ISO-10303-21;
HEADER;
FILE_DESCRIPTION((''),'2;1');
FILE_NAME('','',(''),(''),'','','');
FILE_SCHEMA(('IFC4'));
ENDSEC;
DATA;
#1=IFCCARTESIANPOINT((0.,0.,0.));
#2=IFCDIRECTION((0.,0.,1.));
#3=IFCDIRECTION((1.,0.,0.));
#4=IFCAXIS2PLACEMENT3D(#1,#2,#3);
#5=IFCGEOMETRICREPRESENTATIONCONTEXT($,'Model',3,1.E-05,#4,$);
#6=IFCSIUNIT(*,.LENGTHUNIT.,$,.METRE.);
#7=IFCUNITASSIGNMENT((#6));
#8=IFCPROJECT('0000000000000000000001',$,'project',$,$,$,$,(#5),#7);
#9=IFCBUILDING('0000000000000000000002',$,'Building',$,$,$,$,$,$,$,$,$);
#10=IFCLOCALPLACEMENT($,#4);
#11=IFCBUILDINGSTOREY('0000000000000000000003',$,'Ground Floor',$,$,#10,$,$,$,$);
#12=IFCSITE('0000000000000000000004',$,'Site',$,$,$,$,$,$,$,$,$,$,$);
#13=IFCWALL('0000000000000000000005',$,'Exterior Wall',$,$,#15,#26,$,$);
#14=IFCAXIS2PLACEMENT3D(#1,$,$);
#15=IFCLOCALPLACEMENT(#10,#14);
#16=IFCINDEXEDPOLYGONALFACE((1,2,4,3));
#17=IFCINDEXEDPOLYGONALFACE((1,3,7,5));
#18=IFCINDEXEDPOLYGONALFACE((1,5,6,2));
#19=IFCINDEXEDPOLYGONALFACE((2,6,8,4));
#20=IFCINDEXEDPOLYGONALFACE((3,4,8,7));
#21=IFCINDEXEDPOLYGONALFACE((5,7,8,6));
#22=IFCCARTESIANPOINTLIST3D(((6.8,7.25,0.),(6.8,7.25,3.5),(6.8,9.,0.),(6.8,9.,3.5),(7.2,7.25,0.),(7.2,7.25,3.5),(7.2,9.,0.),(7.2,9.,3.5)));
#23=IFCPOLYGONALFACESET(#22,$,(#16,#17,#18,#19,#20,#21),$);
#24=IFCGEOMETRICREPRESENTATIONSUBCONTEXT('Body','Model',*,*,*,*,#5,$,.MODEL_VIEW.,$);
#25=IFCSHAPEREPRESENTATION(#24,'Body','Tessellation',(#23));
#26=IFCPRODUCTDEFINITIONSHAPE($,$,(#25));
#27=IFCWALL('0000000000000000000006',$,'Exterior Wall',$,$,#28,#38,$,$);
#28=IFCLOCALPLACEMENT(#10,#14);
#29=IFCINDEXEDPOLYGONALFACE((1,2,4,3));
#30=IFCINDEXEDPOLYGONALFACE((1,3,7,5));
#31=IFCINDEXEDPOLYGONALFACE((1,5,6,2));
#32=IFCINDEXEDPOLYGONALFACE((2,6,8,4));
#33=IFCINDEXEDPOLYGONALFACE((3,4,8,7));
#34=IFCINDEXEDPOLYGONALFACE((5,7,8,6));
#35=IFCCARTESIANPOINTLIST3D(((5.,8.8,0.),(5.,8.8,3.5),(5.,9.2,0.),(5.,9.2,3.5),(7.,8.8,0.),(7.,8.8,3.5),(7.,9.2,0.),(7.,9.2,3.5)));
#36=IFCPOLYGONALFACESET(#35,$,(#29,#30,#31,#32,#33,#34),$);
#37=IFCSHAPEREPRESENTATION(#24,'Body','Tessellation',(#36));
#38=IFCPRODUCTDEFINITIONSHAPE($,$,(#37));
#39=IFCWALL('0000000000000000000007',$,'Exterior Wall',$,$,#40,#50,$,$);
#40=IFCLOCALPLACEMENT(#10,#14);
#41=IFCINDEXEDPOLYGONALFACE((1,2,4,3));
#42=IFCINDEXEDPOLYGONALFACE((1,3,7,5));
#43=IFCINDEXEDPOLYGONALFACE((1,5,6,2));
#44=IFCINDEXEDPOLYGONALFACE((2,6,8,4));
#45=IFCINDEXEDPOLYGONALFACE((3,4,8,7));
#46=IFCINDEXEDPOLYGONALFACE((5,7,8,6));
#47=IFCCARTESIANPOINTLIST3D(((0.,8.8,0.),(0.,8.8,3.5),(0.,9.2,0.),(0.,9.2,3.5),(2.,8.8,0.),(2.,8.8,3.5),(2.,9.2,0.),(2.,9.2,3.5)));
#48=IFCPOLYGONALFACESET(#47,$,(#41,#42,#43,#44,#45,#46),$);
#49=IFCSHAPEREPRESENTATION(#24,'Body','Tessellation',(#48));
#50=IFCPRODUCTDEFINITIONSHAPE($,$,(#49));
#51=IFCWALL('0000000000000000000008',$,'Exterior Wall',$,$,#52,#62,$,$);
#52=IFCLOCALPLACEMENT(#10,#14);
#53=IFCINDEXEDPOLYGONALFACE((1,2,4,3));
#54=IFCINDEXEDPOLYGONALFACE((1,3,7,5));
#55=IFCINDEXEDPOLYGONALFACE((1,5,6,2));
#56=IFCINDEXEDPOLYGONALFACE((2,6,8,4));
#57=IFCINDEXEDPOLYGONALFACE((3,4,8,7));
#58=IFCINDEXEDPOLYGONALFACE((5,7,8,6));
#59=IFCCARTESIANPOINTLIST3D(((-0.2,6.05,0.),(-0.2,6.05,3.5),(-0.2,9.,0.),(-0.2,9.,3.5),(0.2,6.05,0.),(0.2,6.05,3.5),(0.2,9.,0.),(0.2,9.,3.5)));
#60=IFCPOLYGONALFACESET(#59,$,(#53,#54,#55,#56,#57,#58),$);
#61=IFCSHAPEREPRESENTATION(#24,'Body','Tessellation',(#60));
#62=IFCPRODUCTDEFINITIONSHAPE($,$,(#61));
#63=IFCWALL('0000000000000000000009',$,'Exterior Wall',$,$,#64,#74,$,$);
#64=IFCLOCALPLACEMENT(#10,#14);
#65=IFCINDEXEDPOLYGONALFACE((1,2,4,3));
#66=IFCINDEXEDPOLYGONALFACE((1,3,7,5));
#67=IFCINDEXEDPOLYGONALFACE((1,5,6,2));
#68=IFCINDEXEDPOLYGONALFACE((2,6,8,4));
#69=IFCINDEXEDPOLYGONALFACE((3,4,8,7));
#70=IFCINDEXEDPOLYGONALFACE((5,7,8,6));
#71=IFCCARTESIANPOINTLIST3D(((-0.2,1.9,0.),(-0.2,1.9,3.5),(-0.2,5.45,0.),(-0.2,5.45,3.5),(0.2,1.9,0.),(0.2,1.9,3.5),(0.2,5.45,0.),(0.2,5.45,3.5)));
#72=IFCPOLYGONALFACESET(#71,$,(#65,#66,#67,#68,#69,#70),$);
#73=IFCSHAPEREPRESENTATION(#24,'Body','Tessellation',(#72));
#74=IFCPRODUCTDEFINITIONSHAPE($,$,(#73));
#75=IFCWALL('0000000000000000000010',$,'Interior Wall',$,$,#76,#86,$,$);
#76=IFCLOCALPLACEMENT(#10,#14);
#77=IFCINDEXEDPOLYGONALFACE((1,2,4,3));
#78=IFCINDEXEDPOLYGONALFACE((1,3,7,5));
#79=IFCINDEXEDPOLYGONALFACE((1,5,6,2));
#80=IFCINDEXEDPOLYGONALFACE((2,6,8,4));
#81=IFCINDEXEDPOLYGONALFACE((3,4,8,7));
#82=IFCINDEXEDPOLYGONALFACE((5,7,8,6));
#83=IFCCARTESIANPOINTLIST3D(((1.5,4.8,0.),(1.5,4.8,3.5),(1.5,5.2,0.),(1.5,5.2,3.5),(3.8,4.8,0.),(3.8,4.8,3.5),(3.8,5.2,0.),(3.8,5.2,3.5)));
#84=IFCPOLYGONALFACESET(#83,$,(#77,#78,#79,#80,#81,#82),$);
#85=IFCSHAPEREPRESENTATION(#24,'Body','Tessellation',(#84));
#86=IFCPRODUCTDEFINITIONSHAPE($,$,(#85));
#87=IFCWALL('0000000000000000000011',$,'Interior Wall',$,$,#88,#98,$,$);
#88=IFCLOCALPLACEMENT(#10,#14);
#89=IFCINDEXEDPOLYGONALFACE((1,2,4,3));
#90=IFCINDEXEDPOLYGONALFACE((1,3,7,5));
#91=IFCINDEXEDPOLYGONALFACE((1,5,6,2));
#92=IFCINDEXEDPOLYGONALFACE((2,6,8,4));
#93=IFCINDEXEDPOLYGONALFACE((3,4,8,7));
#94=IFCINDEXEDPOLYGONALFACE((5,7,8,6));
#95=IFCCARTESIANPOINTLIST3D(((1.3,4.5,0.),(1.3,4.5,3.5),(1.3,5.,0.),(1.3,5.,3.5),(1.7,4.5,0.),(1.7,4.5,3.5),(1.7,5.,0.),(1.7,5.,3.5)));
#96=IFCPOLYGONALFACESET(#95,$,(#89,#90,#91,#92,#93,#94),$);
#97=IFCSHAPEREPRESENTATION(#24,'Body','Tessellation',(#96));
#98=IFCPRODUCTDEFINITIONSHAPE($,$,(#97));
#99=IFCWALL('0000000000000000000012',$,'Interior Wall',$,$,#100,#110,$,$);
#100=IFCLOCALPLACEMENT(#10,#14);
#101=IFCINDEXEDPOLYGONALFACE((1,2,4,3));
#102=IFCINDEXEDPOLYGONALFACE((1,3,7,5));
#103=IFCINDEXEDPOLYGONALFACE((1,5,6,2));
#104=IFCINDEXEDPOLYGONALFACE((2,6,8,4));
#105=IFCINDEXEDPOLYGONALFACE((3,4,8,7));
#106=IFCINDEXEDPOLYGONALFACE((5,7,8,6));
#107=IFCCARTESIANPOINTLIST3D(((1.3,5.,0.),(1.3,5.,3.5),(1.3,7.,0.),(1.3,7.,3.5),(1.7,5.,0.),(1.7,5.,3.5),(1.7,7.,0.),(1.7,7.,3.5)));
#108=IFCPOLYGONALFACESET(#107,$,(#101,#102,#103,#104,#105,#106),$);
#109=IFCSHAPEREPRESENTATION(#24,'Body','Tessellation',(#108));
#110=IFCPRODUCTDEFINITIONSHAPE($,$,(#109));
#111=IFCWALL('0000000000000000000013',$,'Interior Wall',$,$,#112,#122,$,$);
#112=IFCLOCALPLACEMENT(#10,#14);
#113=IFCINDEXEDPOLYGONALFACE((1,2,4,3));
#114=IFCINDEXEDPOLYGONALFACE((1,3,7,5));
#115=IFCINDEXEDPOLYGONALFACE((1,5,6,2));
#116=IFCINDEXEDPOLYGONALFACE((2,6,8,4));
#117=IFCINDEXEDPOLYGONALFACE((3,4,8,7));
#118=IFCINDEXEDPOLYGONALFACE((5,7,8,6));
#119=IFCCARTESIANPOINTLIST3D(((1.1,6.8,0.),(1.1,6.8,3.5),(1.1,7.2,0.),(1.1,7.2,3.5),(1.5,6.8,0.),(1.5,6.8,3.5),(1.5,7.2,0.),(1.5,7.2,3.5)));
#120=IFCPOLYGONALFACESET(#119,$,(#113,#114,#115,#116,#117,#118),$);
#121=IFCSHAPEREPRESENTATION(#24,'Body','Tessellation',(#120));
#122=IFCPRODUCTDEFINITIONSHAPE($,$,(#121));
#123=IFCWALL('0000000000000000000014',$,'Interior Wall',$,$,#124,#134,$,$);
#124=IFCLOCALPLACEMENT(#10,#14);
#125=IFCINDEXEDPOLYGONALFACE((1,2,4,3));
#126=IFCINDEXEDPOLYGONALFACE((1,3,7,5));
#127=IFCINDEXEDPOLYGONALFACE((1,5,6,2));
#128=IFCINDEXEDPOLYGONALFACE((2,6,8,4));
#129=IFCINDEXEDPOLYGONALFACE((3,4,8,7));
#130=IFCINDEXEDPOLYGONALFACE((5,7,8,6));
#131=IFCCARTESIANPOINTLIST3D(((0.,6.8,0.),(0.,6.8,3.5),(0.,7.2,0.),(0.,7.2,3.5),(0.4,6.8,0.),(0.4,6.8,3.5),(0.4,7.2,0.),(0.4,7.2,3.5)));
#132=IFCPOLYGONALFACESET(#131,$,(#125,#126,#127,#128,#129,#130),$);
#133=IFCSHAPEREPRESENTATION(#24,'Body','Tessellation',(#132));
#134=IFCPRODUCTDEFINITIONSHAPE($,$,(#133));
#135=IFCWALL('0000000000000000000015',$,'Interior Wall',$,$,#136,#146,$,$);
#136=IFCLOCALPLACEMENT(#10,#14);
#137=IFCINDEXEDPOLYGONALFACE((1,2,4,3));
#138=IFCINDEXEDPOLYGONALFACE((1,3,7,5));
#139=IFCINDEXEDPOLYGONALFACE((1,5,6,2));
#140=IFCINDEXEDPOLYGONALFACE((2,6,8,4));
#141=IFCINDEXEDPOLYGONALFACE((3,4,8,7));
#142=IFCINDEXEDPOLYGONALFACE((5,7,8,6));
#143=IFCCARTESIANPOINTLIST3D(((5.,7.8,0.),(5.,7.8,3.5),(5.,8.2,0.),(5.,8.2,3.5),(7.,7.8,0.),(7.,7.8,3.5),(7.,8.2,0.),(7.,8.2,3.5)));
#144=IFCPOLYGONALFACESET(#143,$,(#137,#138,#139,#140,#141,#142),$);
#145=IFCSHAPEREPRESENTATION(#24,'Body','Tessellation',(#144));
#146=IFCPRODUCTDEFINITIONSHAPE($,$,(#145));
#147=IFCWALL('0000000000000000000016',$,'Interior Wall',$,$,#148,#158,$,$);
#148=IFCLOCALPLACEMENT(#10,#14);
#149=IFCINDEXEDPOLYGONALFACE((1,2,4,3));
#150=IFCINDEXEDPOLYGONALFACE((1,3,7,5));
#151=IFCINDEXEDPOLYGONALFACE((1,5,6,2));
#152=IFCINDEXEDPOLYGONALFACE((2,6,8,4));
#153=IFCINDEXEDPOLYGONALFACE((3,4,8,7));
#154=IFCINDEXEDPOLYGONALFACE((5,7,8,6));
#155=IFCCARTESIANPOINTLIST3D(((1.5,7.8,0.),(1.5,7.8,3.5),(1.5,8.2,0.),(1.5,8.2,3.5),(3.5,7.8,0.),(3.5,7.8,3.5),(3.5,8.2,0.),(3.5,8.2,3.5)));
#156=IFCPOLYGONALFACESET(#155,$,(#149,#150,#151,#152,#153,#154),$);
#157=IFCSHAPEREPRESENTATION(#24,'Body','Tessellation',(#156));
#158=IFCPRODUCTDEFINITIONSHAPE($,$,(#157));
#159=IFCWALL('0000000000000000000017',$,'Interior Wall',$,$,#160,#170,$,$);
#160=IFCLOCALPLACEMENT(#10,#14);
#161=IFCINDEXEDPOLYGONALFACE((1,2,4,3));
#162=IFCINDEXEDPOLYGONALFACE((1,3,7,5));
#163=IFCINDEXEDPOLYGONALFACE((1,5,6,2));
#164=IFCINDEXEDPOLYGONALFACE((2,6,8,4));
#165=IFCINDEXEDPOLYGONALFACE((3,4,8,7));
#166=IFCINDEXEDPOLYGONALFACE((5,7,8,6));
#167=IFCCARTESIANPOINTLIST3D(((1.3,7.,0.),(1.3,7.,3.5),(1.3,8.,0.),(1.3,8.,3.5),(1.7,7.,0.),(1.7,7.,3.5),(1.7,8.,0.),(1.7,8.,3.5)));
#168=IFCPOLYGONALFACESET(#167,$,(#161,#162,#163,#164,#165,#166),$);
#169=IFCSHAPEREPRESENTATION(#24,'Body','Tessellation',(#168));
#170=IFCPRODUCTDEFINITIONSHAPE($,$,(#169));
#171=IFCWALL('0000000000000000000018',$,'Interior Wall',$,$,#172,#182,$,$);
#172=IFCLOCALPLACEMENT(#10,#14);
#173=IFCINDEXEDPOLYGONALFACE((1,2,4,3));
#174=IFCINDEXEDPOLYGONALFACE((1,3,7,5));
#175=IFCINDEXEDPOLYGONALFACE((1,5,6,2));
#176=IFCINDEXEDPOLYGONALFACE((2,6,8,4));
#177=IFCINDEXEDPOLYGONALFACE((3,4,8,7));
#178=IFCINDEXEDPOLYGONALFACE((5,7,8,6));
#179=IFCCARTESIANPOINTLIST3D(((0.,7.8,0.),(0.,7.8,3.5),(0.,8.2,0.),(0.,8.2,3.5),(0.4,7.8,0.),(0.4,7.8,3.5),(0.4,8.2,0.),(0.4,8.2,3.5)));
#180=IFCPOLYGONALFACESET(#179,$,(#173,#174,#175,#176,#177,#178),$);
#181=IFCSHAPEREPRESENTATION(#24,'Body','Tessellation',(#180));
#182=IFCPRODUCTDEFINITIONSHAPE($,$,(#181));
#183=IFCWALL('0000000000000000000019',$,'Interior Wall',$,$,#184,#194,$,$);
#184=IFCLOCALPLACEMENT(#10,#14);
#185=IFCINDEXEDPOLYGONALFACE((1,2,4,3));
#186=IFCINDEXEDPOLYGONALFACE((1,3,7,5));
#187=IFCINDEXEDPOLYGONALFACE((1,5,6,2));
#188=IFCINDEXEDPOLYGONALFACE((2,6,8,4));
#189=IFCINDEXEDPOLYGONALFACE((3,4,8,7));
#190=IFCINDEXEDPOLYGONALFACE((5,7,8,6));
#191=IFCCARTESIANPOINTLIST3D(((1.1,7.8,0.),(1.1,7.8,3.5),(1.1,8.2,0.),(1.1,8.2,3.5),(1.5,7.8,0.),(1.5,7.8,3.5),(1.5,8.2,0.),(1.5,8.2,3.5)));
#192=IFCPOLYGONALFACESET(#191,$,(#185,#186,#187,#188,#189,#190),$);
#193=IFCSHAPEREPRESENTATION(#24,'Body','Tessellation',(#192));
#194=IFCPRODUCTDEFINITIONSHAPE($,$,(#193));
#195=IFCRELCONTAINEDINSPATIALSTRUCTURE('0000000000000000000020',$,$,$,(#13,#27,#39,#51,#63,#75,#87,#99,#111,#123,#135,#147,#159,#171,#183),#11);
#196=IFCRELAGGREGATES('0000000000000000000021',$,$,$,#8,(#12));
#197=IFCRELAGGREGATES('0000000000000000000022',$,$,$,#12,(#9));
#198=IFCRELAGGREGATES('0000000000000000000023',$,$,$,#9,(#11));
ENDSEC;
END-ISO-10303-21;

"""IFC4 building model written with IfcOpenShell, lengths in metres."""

from ifc_helpers import new_model, si_unit, frame, origin_with_axes, place, context, subcontext, project, spatial, indexed_curve, outline, extrude, element, save


model = new_model("IFC4")

# Units and contexts
model_context = context("Model", 3, precision=1e-05, world=origin_with_axes())
body_context = subcontext(model_context, "Body", "Model", "MODEL_VIEW")
ifc_project = project(units=[si_unit("LENGTHUNIT", "METRE")], contexts=[model_context])

# Site, building, storey
site = spatial("IfcSite", under=ifc_project, Name="Site")
building = spatial("IfcBuilding", under=site, Name="Building")
storey_placement = place(None, origin_with_axes())
storey = spatial("IfcBuildingStorey", under=building, at=storey_placement, Name="Ground Floor")

# Walls
wall_1_placement = place(storey_placement, frame((7.0, 7.25, 0.0), z_axis=(0.0, 0.0, 1.0), x_axis=(0.0, 1.0, 0.0)))
element("IfcWall", 1, at=wall_1_placement, inside=storey, Name="Exterior Wall", context=body_context, shape_type="SweptSolid", body=[
    extrude(outline(indexed_curve([(0.0, 0.0), (0.0, 0.4), (1.75, 0.4), (1.75, 0.0), (0.0, 0.0)], self_intersect=False)), frame((0.0, -0.2, 0.0), z_axis=(0.0, 0.0, 1.0), x_axis=(1.0, 0.0, 0.0)), (0.0, 0.0, 1.0), 3.5),
])
for number, where, z_axis, x_axis, name in (
    (2, (7.0, 9.0, 0.0), (0.0, 0.0, 1.0), (-1.0, 0.0, 0.0), "Exterior Wall"),
    (3, (2.0, 9.0, 0.0), (0.0, 0.0, 1.0), (-1.0, 0.0, 0.0), "Exterior Wall"),
):
    element("IfcWall", number, at=place(storey_placement, frame(where, z_axis=z_axis, x_axis=x_axis)), inside=storey, Name=name, context=body_context, shape_type="SweptSolid", body=[
        extrude(outline(indexed_curve([(0.0, 0.0), (0.0, 0.4), (2.0, 0.4), (2.0, 0.0), (0.0, 0.0)], self_intersect=False)), frame((0.0, -0.2, 0.0), z_axis=(0.0, 0.0, 1.0), x_axis=(1.0, 0.0, 0.0)), (0.0, 0.0, 1.0), 3.5),
    ])
wall_2_placement = place(storey_placement, frame((0.0, 9.0, 0.0), z_axis=(0.0, 0.0, 1.0), x_axis=(0.0, -1.0, 0.0)))
element("IfcWall", 4, at=wall_2_placement, inside=storey, Name="Exterior Wall", context=body_context, shape_type="SweptSolid", body=[
    extrude(outline(indexed_curve([(0.0, 0.0), (0.0, 0.4), (2.95, 0.4), (2.95, 0.0), (0.0, 0.0)], self_intersect=False)), frame((0.0, -0.2, 0.0), z_axis=(0.0, 0.0, 1.0), x_axis=(1.0, 0.0, 0.0)), (0.0, 0.0, 1.0), 3.5),
])
wall_3_placement = place(storey_placement, frame((0.0, 5.45, 0.0), z_axis=(0.0, 0.0, 1.0), x_axis=(0.0, -1.0, 0.0)))
element("IfcWall", 5, at=wall_3_placement, inside=storey, Name="Exterior Wall", context=body_context, shape_type="SweptSolid", body=[
    extrude(outline(indexed_curve([(0.0, 0.0), (0.0, 0.4), (3.55, 0.4), (3.55, 0.0), (0.0, 0.0)], self_intersect=False)), frame((0.0, -0.2, 0.0), z_axis=(0.0, 0.0, 1.0), x_axis=(1.0, 0.0, 0.0)), (0.0, 0.0, 1.0), 3.5),
])
wall_4_placement = place(storey_placement, frame((3.8, 5.0, 0.0), z_axis=(0.0, 0.0, 1.0), x_axis=(-1.0, 0.0, 0.0)))
element("IfcWall", 6, at=wall_4_placement, inside=storey, Name="Interior Wall", context=body_context, shape_type="SweptSolid", body=[
    extrude(outline(indexed_curve([(0.0, 0.0), (0.0, 0.4), (2.3, 0.4), (2.3, 0.0), (0.0, 0.0)], self_intersect=False)), frame((0.0, -0.2, 0.0), z_axis=(0.0, 0.0, 1.0), x_axis=(1.0, 0.0, 0.0)), (0.0, 0.0, 1.0), 3.5),
])
wall_5_placement = place(storey_placement, frame((1.5, 5.0, 0.0), z_axis=(0.0, 0.0, 1.0), x_axis=(0.0, -1.0, 0.0)))
element("IfcWall", 7, at=wall_5_placement, inside=storey, Name="Interior Wall", context=body_context, shape_type="SweptSolid", body=[
    extrude(outline(indexed_curve([(0.0, 0.0), (0.0, 0.4), (0.5, 0.4), (0.5, 0.0), (0.0, 0.0)], self_intersect=False)), frame((0.0, -0.2, 0.0), z_axis=(0.0, 0.0, 1.0), x_axis=(1.0, 0.0, 0.0)), (0.0, 0.0, 1.0), 3.5),
])
wall_6_placement = place(storey_placement, frame((1.5, 5.0, 0.0), z_axis=(0.0, 0.0, 1.0), x_axis=(0.0, 1.0, 0.0)))
element("IfcWall", 8, at=wall_6_placement, inside=storey, Name="Interior Wall", context=body_context, shape_type="SweptSolid", body=[
    extrude(outline(indexed_curve([(0.0, 0.0), (0.0, 0.4), (2.0, 0.4), (2.0, 0.0), (0.0, 0.0)], self_intersect=False)), frame((0.0, -0.2, 0.0), z_axis=(0.0, 0.0, 1.0), x_axis=(1.0, 0.0, 0.0)), (0.0, 0.0, 1.0), 3.5),
])
for number, where, z_axis, x_axis, name in (
    (9, (1.5, 7.0, 0.0), (0.0, 0.0, 1.0), (-1.0, 0.0, 0.0), "Interior Wall"),
    (10, (0.4, 7.0, 0.0), (0.0, 0.0, 1.0), (-1.0, 0.0, 0.0), "Interior Wall"),
):
    element("IfcWall", number, at=place(storey_placement, frame(where, z_axis=z_axis, x_axis=x_axis)), inside=storey, Name=name, context=body_context, shape_type="SweptSolid", body=[
        extrude(outline(indexed_curve([(0.0, 0.0), (0.0, 0.4), (0.4, 0.4), (0.4, 0.0), (0.0, 0.0)], self_intersect=False)), frame((0.0, -0.2, 0.0), z_axis=(0.0, 0.0, 1.0), x_axis=(1.0, 0.0, 0.0)), (0.0, 0.0, 1.0), 3.5),
    ])
for number, where, z_axis, x_axis, name in (
    (11, (7.0, 8.0, 0.0), (0.0, 0.0, 1.0), (-1.0, 0.0, 0.0), "Interior Wall"),
    (12, (3.5, 8.0, 0.0), (0.0, 0.0, 1.0), (-1.0, 0.0, 0.0), "Interior Wall"),
):
    element("IfcWall", number, at=place(storey_placement, frame(where, z_axis=z_axis, x_axis=x_axis)), inside=storey, Name=name, context=body_context, shape_type="SweptSolid", body=[
        extrude(outline(indexed_curve([(0.0, 0.0), (0.0, 0.4), (2.0, 0.4), (2.0, 0.0), (0.0, 0.0)], self_intersect=False)), frame((0.0, -0.2, 0.0), z_axis=(0.0, 0.0, 1.0), x_axis=(1.0, 0.0, 0.0)), (0.0, 0.0, 1.0), 3.5),
    ])
wall_7_placement = place(storey_placement, frame((1.5, 8.0, 0.0), z_axis=(0.0, 0.0, 1.0), x_axis=(0.0, -1.0, 0.0)))
element("IfcWall", 13, at=wall_7_placement, inside=storey, Name="Interior Wall", context=body_context, shape_type="SweptSolid", body=[
    extrude(outline(indexed_curve([(0.0, 0.0), (0.0, 0.4), (1.0, 0.4), (1.0, 0.0), (0.0, 0.0)], self_intersect=False)), frame((0.0, -0.2, 0.0), z_axis=(0.0, 0.0, 1.0), x_axis=(1.0, 0.0, 0.0)), (0.0, 0.0, 1.0), 3.5),
])
wall_8_placement = place(storey_placement, frame((0.0, 8.0, 0.0), z_axis=(0.0, 0.0, 1.0), x_axis=(1.0, 0.0, 0.0)))
element("IfcWall", 14, at=wall_8_placement, inside=storey, Name="Interior Wall", context=body_context, shape_type="SweptSolid", body=[
    extrude(outline(indexed_curve([(0.0, 0.0), (0.0, 0.4), (0.4, 0.4), (0.4, 0.0), (0.0, 0.0)], self_intersect=False)), frame((0.0, -0.2, 0.0), z_axis=(0.0, 0.0, 1.0), x_axis=(1.0, 0.0, 0.0)), (0.0, 0.0, 1.0), 3.5),
])
wall_9_placement = place(storey_placement, frame((1.1, 8.0, 0.0), z_axis=(0.0, 0.0, 1.0), x_axis=(1.0, 0.0, 0.0)))
element("IfcWall", 15, at=wall_9_placement, inside=storey, Name="Interior Wall", context=body_context, shape_type="SweptSolid", body=[
    extrude(outline(indexed_curve([(0.0, 0.0), (0.0, 0.4), (0.4, 0.4), (0.4, 0.0), (0.0, 0.0)], self_intersect=False)), frame((0.0, -0.2, 0.0), z_axis=(0.0, 0.0, 1.0), x_axis=(1.0, 0.0, 0.0)), (0.0, 0.0, 1.0), 3.5),
])

save(model, "model.ifc")
